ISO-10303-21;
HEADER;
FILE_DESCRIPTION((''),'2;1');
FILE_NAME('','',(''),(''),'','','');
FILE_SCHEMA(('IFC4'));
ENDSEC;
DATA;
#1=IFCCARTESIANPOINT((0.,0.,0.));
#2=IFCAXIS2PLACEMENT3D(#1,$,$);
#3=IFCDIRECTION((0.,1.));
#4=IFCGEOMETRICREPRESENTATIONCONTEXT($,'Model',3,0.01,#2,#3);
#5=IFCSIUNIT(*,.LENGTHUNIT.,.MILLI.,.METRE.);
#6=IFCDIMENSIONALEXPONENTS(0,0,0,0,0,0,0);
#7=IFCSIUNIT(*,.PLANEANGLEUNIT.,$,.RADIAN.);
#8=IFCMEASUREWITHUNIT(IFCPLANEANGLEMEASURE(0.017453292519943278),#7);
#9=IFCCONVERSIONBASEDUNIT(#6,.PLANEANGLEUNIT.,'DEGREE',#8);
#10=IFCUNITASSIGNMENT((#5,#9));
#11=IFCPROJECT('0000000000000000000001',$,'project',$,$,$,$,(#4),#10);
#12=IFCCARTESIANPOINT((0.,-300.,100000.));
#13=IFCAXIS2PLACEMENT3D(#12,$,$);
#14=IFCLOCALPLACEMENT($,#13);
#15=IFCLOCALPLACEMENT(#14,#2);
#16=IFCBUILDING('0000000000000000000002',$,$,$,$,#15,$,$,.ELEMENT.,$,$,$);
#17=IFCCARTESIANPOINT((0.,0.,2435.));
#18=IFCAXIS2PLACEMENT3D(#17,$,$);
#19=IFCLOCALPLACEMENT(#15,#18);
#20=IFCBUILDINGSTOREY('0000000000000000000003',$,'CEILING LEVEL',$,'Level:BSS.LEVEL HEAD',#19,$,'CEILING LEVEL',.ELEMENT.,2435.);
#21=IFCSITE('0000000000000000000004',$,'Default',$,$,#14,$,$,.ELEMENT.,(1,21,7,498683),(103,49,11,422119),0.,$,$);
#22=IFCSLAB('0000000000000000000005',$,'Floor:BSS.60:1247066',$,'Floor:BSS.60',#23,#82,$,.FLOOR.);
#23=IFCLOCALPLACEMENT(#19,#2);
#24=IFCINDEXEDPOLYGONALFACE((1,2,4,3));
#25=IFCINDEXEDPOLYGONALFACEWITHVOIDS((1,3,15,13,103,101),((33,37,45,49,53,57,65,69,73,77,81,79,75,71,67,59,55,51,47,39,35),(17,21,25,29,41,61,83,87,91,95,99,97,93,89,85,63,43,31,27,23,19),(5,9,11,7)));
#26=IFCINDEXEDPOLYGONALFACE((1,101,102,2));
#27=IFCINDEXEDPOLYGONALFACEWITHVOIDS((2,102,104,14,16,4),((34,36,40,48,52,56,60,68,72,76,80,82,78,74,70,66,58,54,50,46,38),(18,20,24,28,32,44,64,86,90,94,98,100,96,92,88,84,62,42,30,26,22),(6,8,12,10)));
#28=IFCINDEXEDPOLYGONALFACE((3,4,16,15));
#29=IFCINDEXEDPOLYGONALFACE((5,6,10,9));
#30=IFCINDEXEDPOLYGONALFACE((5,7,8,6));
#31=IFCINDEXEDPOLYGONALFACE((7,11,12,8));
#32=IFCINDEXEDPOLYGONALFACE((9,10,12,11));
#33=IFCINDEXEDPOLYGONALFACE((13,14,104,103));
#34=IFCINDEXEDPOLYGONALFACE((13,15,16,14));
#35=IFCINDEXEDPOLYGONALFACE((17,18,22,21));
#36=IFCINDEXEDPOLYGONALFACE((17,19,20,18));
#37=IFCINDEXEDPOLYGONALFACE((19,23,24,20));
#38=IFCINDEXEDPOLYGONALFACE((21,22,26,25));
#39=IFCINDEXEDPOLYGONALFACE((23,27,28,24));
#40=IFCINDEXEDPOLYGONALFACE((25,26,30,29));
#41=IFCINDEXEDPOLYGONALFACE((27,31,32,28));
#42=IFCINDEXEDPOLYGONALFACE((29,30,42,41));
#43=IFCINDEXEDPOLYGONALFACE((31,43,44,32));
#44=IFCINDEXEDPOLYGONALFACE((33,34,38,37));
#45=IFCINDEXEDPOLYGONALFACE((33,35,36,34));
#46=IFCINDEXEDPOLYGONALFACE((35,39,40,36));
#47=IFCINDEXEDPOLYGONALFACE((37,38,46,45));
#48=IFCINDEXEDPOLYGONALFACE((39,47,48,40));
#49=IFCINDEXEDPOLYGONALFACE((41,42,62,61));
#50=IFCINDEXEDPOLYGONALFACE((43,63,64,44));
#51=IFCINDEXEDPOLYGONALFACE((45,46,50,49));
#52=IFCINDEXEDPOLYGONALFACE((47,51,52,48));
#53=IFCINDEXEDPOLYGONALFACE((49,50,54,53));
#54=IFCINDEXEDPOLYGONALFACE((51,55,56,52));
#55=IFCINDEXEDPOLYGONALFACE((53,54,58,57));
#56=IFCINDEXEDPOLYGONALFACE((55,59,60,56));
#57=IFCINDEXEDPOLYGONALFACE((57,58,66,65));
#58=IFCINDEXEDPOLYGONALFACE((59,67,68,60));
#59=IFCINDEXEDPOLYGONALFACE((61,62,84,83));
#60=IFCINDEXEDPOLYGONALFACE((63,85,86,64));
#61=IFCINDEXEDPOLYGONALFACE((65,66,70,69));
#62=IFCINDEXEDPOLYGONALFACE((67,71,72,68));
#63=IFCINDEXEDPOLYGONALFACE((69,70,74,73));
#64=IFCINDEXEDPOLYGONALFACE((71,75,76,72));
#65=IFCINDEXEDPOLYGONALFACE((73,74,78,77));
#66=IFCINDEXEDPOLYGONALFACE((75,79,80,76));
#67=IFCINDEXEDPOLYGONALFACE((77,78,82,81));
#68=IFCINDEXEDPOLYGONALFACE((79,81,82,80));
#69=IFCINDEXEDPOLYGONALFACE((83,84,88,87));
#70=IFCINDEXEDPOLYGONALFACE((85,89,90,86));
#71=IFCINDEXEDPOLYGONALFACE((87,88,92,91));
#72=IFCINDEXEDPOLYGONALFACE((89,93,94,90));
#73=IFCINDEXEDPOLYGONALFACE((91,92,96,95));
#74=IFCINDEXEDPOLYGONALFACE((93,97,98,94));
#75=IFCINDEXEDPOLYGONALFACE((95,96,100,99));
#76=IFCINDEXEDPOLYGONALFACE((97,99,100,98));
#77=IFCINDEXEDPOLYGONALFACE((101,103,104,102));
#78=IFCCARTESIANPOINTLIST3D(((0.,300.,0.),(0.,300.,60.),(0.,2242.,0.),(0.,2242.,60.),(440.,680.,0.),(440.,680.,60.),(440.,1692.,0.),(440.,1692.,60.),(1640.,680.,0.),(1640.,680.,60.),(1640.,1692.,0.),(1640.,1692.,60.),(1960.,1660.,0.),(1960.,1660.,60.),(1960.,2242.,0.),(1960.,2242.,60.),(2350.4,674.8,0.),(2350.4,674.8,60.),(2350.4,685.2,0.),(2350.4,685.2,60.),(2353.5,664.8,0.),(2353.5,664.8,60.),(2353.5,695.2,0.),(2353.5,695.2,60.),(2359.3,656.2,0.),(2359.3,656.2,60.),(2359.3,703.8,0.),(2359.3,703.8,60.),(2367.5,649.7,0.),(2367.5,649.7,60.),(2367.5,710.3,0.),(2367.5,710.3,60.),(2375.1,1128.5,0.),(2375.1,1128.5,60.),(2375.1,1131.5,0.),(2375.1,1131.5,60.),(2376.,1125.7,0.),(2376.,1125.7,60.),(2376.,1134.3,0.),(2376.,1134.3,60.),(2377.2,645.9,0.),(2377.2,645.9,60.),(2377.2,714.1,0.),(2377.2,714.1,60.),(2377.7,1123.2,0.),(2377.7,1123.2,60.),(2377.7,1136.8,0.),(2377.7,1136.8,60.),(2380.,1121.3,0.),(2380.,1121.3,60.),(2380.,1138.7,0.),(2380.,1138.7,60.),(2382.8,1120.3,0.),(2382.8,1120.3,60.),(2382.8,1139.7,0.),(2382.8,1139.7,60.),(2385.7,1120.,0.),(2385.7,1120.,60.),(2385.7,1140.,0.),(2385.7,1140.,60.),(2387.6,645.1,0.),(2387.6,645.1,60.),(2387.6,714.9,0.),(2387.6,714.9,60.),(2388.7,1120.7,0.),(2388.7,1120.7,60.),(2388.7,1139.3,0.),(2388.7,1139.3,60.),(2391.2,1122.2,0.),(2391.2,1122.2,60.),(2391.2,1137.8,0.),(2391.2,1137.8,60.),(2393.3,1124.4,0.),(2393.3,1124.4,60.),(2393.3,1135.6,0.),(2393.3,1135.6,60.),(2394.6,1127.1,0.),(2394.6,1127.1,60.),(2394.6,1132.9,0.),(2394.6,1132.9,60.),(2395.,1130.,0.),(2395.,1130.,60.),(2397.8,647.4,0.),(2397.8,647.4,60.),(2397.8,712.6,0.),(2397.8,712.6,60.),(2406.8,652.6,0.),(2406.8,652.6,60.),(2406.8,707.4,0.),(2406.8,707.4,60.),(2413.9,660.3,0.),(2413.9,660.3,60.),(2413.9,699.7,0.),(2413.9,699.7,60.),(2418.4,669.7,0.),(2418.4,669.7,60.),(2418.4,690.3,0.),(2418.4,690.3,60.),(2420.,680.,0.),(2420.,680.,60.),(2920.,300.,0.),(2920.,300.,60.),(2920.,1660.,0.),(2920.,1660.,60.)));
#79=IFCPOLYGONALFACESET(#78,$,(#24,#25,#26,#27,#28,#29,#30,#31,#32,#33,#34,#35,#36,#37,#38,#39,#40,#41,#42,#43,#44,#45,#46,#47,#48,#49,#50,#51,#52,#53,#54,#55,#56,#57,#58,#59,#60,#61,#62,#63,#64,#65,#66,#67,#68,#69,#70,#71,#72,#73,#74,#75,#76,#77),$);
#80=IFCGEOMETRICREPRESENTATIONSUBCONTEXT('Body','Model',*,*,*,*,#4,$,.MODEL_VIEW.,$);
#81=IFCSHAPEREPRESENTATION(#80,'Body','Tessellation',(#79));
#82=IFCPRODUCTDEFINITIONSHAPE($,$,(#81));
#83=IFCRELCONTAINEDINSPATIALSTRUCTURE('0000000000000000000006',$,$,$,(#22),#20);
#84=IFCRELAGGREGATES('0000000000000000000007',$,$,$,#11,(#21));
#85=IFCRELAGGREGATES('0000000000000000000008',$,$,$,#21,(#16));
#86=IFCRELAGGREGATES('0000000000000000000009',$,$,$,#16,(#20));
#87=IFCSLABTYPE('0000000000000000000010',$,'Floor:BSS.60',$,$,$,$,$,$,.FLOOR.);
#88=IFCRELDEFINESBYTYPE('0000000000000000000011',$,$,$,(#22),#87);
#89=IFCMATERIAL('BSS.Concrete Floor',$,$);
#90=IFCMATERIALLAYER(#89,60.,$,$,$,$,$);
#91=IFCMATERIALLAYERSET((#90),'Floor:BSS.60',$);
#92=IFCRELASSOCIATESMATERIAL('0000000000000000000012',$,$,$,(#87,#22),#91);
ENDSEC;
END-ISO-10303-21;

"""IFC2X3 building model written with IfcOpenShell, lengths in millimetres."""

from ifc_helpers import new_model, entity, si_unit, converted_unit, direction, frame, frame_2d, origin, origin_2d_with_axis, place, context, subcontext, project, spatial, polyline, rectangle, circle, outline, extrude, material, layer, layer_set, layer_usage, type_object, element, save


model = new_model("IFC2X3")

# Units and contexts
model_context = context("Model", 3, precision=0.01, world=origin(), true_north=direction((0.0, 1.0)))
body_context = subcontext(model_context, "Body", "Model", "MODEL_VIEW")
ifc_project = project(units=[si_unit("LENGTHUNIT", "METRE", prefix="MILLI"), converted_unit("PLANEANGLEUNIT", "DEGREE", entity("IfcPlaneAngleMeasure", 0.017453292519943278), si_unit("PLANEANGLEUNIT", "RADIAN"), dimensions=[0, 0, 0, 0, 0, 0, 0])], contexts=[model_context])

# Site, building, storey
site_placement = place(None, frame((0.0, -300.0, 100000.0)))
site = spatial("IfcSite", under=ifc_project, at=site_placement, Name="Default", CompositionType="ELEMENT", RefLatitude=(1, 21, 7, 498683), RefLongitude=(103, 49, 11, 422119), RefElevation=0.0)
building_placement = place(site_placement, origin())
building = spatial("IfcBuilding", under=site, at=building_placement, CompositionType="ELEMENT")
storey_placement = place(building_placement, frame((0.0, 0.0, 2435.0)))
storey = spatial("IfcBuildingStorey", under=building, at=storey_placement, Name="CEILING LEVEL", ObjectType="Level:BSS.LEVEL HEAD", LongName="CEILING LEVEL", CompositionType="ELEMENT", Elevation=2435.0)

# Slab, openings
ifc_material = material(Name="BSS.Concrete Floor")
ifc_layer = layer(ifc_material, 60.0)
ifc_layer_set = layer_set([ifc_layer], Name="Floor:BSS.60")
ifc_layer_usage = layer_usage(ifc_layer_set, "AXIS3", "POSITIVE", 0.0)
slab_type = type_object("IfcSlabType", Name="Floor:BSS.60", PredefinedType="FLOOR", material=ifc_layer_set)
slab_placement = place(storey_placement, frame((0.0, 300.0, 0.0)))
slab = element("IfcSlab", 1, at=slab_placement, inside=storey, type_object=slab_type, material=ifc_layer_usage, Name="Floor:BSS.60:1247066", ObjectType="Floor:BSS.60", PredefinedType="FLOOR", context=body_context, shape_type="SweptSolid", body=[
    extrude(outline(polyline([(1460.0, -971.0), (1460.0, 971.0), (-500.0, 971.0), (-500.0, 389.0), (-1460.0, 389.0), (-1460.0, -971.0), (1460.0, -971.0)])), frame((1460.0, 971.0, 60.0), z_axis=(0.0, 0.0, -1.0), x_axis=(-1.0, 0.0, 0.0)), (0.0, 0.0, 1.0), 60.0),
])
opening_1_placement = place(slab_placement, origin())
element("IfcOpeningElement", 2, at=opening_1_placement, cuts=slab, ObjectType="Opening", context=body_context, shape_type="SweptSolid", body=[
    extrude(rectangle(XDim=1012.0, YDim=1200.0, at=frame_2d((0.0, 0.0), x_axis=(1.0, 0.0))), frame((1040.0, 886.0, 60.0), z_axis=(0.0, 0.0, -1.0), x_axis=(0.0, -1.0, 0.0)), (0.0, 0.0, 1.0), 60.0),
])
opening_2_placement = place(slab_placement, origin())
element("IfcOpeningElement", 3, at=opening_2_placement, cuts=slab, ObjectType="Opening", context=body_context, shape_type="SweptSolid", body=[
    extrude(circle(Radius=10.0, at=origin_2d_with_axis()), frame((2385.0, 830.0, 60.0), z_axis=(0.0, 0.0, -1.0), x_axis=(1.0, 0.0, 0.0)), (0.0, 0.0, 1.0), 60.0),
])
opening_3_placement = place(slab_placement, origin())
element("IfcOpeningElement", 4, at=opening_3_placement, cuts=slab, ObjectType="Opening", context=body_context, shape_type="SweptSolid", body=[
    extrude(circle(Radius=35.0, at=origin_2d_with_axis()), frame((2385.0, 380.0, 60.0), z_axis=(0.0, 0.0, -1.0), x_axis=(1.0, 0.0, 0.0)), (0.0, 0.0, 1.0), 60.0),
])

save(model, "model.ifc")
